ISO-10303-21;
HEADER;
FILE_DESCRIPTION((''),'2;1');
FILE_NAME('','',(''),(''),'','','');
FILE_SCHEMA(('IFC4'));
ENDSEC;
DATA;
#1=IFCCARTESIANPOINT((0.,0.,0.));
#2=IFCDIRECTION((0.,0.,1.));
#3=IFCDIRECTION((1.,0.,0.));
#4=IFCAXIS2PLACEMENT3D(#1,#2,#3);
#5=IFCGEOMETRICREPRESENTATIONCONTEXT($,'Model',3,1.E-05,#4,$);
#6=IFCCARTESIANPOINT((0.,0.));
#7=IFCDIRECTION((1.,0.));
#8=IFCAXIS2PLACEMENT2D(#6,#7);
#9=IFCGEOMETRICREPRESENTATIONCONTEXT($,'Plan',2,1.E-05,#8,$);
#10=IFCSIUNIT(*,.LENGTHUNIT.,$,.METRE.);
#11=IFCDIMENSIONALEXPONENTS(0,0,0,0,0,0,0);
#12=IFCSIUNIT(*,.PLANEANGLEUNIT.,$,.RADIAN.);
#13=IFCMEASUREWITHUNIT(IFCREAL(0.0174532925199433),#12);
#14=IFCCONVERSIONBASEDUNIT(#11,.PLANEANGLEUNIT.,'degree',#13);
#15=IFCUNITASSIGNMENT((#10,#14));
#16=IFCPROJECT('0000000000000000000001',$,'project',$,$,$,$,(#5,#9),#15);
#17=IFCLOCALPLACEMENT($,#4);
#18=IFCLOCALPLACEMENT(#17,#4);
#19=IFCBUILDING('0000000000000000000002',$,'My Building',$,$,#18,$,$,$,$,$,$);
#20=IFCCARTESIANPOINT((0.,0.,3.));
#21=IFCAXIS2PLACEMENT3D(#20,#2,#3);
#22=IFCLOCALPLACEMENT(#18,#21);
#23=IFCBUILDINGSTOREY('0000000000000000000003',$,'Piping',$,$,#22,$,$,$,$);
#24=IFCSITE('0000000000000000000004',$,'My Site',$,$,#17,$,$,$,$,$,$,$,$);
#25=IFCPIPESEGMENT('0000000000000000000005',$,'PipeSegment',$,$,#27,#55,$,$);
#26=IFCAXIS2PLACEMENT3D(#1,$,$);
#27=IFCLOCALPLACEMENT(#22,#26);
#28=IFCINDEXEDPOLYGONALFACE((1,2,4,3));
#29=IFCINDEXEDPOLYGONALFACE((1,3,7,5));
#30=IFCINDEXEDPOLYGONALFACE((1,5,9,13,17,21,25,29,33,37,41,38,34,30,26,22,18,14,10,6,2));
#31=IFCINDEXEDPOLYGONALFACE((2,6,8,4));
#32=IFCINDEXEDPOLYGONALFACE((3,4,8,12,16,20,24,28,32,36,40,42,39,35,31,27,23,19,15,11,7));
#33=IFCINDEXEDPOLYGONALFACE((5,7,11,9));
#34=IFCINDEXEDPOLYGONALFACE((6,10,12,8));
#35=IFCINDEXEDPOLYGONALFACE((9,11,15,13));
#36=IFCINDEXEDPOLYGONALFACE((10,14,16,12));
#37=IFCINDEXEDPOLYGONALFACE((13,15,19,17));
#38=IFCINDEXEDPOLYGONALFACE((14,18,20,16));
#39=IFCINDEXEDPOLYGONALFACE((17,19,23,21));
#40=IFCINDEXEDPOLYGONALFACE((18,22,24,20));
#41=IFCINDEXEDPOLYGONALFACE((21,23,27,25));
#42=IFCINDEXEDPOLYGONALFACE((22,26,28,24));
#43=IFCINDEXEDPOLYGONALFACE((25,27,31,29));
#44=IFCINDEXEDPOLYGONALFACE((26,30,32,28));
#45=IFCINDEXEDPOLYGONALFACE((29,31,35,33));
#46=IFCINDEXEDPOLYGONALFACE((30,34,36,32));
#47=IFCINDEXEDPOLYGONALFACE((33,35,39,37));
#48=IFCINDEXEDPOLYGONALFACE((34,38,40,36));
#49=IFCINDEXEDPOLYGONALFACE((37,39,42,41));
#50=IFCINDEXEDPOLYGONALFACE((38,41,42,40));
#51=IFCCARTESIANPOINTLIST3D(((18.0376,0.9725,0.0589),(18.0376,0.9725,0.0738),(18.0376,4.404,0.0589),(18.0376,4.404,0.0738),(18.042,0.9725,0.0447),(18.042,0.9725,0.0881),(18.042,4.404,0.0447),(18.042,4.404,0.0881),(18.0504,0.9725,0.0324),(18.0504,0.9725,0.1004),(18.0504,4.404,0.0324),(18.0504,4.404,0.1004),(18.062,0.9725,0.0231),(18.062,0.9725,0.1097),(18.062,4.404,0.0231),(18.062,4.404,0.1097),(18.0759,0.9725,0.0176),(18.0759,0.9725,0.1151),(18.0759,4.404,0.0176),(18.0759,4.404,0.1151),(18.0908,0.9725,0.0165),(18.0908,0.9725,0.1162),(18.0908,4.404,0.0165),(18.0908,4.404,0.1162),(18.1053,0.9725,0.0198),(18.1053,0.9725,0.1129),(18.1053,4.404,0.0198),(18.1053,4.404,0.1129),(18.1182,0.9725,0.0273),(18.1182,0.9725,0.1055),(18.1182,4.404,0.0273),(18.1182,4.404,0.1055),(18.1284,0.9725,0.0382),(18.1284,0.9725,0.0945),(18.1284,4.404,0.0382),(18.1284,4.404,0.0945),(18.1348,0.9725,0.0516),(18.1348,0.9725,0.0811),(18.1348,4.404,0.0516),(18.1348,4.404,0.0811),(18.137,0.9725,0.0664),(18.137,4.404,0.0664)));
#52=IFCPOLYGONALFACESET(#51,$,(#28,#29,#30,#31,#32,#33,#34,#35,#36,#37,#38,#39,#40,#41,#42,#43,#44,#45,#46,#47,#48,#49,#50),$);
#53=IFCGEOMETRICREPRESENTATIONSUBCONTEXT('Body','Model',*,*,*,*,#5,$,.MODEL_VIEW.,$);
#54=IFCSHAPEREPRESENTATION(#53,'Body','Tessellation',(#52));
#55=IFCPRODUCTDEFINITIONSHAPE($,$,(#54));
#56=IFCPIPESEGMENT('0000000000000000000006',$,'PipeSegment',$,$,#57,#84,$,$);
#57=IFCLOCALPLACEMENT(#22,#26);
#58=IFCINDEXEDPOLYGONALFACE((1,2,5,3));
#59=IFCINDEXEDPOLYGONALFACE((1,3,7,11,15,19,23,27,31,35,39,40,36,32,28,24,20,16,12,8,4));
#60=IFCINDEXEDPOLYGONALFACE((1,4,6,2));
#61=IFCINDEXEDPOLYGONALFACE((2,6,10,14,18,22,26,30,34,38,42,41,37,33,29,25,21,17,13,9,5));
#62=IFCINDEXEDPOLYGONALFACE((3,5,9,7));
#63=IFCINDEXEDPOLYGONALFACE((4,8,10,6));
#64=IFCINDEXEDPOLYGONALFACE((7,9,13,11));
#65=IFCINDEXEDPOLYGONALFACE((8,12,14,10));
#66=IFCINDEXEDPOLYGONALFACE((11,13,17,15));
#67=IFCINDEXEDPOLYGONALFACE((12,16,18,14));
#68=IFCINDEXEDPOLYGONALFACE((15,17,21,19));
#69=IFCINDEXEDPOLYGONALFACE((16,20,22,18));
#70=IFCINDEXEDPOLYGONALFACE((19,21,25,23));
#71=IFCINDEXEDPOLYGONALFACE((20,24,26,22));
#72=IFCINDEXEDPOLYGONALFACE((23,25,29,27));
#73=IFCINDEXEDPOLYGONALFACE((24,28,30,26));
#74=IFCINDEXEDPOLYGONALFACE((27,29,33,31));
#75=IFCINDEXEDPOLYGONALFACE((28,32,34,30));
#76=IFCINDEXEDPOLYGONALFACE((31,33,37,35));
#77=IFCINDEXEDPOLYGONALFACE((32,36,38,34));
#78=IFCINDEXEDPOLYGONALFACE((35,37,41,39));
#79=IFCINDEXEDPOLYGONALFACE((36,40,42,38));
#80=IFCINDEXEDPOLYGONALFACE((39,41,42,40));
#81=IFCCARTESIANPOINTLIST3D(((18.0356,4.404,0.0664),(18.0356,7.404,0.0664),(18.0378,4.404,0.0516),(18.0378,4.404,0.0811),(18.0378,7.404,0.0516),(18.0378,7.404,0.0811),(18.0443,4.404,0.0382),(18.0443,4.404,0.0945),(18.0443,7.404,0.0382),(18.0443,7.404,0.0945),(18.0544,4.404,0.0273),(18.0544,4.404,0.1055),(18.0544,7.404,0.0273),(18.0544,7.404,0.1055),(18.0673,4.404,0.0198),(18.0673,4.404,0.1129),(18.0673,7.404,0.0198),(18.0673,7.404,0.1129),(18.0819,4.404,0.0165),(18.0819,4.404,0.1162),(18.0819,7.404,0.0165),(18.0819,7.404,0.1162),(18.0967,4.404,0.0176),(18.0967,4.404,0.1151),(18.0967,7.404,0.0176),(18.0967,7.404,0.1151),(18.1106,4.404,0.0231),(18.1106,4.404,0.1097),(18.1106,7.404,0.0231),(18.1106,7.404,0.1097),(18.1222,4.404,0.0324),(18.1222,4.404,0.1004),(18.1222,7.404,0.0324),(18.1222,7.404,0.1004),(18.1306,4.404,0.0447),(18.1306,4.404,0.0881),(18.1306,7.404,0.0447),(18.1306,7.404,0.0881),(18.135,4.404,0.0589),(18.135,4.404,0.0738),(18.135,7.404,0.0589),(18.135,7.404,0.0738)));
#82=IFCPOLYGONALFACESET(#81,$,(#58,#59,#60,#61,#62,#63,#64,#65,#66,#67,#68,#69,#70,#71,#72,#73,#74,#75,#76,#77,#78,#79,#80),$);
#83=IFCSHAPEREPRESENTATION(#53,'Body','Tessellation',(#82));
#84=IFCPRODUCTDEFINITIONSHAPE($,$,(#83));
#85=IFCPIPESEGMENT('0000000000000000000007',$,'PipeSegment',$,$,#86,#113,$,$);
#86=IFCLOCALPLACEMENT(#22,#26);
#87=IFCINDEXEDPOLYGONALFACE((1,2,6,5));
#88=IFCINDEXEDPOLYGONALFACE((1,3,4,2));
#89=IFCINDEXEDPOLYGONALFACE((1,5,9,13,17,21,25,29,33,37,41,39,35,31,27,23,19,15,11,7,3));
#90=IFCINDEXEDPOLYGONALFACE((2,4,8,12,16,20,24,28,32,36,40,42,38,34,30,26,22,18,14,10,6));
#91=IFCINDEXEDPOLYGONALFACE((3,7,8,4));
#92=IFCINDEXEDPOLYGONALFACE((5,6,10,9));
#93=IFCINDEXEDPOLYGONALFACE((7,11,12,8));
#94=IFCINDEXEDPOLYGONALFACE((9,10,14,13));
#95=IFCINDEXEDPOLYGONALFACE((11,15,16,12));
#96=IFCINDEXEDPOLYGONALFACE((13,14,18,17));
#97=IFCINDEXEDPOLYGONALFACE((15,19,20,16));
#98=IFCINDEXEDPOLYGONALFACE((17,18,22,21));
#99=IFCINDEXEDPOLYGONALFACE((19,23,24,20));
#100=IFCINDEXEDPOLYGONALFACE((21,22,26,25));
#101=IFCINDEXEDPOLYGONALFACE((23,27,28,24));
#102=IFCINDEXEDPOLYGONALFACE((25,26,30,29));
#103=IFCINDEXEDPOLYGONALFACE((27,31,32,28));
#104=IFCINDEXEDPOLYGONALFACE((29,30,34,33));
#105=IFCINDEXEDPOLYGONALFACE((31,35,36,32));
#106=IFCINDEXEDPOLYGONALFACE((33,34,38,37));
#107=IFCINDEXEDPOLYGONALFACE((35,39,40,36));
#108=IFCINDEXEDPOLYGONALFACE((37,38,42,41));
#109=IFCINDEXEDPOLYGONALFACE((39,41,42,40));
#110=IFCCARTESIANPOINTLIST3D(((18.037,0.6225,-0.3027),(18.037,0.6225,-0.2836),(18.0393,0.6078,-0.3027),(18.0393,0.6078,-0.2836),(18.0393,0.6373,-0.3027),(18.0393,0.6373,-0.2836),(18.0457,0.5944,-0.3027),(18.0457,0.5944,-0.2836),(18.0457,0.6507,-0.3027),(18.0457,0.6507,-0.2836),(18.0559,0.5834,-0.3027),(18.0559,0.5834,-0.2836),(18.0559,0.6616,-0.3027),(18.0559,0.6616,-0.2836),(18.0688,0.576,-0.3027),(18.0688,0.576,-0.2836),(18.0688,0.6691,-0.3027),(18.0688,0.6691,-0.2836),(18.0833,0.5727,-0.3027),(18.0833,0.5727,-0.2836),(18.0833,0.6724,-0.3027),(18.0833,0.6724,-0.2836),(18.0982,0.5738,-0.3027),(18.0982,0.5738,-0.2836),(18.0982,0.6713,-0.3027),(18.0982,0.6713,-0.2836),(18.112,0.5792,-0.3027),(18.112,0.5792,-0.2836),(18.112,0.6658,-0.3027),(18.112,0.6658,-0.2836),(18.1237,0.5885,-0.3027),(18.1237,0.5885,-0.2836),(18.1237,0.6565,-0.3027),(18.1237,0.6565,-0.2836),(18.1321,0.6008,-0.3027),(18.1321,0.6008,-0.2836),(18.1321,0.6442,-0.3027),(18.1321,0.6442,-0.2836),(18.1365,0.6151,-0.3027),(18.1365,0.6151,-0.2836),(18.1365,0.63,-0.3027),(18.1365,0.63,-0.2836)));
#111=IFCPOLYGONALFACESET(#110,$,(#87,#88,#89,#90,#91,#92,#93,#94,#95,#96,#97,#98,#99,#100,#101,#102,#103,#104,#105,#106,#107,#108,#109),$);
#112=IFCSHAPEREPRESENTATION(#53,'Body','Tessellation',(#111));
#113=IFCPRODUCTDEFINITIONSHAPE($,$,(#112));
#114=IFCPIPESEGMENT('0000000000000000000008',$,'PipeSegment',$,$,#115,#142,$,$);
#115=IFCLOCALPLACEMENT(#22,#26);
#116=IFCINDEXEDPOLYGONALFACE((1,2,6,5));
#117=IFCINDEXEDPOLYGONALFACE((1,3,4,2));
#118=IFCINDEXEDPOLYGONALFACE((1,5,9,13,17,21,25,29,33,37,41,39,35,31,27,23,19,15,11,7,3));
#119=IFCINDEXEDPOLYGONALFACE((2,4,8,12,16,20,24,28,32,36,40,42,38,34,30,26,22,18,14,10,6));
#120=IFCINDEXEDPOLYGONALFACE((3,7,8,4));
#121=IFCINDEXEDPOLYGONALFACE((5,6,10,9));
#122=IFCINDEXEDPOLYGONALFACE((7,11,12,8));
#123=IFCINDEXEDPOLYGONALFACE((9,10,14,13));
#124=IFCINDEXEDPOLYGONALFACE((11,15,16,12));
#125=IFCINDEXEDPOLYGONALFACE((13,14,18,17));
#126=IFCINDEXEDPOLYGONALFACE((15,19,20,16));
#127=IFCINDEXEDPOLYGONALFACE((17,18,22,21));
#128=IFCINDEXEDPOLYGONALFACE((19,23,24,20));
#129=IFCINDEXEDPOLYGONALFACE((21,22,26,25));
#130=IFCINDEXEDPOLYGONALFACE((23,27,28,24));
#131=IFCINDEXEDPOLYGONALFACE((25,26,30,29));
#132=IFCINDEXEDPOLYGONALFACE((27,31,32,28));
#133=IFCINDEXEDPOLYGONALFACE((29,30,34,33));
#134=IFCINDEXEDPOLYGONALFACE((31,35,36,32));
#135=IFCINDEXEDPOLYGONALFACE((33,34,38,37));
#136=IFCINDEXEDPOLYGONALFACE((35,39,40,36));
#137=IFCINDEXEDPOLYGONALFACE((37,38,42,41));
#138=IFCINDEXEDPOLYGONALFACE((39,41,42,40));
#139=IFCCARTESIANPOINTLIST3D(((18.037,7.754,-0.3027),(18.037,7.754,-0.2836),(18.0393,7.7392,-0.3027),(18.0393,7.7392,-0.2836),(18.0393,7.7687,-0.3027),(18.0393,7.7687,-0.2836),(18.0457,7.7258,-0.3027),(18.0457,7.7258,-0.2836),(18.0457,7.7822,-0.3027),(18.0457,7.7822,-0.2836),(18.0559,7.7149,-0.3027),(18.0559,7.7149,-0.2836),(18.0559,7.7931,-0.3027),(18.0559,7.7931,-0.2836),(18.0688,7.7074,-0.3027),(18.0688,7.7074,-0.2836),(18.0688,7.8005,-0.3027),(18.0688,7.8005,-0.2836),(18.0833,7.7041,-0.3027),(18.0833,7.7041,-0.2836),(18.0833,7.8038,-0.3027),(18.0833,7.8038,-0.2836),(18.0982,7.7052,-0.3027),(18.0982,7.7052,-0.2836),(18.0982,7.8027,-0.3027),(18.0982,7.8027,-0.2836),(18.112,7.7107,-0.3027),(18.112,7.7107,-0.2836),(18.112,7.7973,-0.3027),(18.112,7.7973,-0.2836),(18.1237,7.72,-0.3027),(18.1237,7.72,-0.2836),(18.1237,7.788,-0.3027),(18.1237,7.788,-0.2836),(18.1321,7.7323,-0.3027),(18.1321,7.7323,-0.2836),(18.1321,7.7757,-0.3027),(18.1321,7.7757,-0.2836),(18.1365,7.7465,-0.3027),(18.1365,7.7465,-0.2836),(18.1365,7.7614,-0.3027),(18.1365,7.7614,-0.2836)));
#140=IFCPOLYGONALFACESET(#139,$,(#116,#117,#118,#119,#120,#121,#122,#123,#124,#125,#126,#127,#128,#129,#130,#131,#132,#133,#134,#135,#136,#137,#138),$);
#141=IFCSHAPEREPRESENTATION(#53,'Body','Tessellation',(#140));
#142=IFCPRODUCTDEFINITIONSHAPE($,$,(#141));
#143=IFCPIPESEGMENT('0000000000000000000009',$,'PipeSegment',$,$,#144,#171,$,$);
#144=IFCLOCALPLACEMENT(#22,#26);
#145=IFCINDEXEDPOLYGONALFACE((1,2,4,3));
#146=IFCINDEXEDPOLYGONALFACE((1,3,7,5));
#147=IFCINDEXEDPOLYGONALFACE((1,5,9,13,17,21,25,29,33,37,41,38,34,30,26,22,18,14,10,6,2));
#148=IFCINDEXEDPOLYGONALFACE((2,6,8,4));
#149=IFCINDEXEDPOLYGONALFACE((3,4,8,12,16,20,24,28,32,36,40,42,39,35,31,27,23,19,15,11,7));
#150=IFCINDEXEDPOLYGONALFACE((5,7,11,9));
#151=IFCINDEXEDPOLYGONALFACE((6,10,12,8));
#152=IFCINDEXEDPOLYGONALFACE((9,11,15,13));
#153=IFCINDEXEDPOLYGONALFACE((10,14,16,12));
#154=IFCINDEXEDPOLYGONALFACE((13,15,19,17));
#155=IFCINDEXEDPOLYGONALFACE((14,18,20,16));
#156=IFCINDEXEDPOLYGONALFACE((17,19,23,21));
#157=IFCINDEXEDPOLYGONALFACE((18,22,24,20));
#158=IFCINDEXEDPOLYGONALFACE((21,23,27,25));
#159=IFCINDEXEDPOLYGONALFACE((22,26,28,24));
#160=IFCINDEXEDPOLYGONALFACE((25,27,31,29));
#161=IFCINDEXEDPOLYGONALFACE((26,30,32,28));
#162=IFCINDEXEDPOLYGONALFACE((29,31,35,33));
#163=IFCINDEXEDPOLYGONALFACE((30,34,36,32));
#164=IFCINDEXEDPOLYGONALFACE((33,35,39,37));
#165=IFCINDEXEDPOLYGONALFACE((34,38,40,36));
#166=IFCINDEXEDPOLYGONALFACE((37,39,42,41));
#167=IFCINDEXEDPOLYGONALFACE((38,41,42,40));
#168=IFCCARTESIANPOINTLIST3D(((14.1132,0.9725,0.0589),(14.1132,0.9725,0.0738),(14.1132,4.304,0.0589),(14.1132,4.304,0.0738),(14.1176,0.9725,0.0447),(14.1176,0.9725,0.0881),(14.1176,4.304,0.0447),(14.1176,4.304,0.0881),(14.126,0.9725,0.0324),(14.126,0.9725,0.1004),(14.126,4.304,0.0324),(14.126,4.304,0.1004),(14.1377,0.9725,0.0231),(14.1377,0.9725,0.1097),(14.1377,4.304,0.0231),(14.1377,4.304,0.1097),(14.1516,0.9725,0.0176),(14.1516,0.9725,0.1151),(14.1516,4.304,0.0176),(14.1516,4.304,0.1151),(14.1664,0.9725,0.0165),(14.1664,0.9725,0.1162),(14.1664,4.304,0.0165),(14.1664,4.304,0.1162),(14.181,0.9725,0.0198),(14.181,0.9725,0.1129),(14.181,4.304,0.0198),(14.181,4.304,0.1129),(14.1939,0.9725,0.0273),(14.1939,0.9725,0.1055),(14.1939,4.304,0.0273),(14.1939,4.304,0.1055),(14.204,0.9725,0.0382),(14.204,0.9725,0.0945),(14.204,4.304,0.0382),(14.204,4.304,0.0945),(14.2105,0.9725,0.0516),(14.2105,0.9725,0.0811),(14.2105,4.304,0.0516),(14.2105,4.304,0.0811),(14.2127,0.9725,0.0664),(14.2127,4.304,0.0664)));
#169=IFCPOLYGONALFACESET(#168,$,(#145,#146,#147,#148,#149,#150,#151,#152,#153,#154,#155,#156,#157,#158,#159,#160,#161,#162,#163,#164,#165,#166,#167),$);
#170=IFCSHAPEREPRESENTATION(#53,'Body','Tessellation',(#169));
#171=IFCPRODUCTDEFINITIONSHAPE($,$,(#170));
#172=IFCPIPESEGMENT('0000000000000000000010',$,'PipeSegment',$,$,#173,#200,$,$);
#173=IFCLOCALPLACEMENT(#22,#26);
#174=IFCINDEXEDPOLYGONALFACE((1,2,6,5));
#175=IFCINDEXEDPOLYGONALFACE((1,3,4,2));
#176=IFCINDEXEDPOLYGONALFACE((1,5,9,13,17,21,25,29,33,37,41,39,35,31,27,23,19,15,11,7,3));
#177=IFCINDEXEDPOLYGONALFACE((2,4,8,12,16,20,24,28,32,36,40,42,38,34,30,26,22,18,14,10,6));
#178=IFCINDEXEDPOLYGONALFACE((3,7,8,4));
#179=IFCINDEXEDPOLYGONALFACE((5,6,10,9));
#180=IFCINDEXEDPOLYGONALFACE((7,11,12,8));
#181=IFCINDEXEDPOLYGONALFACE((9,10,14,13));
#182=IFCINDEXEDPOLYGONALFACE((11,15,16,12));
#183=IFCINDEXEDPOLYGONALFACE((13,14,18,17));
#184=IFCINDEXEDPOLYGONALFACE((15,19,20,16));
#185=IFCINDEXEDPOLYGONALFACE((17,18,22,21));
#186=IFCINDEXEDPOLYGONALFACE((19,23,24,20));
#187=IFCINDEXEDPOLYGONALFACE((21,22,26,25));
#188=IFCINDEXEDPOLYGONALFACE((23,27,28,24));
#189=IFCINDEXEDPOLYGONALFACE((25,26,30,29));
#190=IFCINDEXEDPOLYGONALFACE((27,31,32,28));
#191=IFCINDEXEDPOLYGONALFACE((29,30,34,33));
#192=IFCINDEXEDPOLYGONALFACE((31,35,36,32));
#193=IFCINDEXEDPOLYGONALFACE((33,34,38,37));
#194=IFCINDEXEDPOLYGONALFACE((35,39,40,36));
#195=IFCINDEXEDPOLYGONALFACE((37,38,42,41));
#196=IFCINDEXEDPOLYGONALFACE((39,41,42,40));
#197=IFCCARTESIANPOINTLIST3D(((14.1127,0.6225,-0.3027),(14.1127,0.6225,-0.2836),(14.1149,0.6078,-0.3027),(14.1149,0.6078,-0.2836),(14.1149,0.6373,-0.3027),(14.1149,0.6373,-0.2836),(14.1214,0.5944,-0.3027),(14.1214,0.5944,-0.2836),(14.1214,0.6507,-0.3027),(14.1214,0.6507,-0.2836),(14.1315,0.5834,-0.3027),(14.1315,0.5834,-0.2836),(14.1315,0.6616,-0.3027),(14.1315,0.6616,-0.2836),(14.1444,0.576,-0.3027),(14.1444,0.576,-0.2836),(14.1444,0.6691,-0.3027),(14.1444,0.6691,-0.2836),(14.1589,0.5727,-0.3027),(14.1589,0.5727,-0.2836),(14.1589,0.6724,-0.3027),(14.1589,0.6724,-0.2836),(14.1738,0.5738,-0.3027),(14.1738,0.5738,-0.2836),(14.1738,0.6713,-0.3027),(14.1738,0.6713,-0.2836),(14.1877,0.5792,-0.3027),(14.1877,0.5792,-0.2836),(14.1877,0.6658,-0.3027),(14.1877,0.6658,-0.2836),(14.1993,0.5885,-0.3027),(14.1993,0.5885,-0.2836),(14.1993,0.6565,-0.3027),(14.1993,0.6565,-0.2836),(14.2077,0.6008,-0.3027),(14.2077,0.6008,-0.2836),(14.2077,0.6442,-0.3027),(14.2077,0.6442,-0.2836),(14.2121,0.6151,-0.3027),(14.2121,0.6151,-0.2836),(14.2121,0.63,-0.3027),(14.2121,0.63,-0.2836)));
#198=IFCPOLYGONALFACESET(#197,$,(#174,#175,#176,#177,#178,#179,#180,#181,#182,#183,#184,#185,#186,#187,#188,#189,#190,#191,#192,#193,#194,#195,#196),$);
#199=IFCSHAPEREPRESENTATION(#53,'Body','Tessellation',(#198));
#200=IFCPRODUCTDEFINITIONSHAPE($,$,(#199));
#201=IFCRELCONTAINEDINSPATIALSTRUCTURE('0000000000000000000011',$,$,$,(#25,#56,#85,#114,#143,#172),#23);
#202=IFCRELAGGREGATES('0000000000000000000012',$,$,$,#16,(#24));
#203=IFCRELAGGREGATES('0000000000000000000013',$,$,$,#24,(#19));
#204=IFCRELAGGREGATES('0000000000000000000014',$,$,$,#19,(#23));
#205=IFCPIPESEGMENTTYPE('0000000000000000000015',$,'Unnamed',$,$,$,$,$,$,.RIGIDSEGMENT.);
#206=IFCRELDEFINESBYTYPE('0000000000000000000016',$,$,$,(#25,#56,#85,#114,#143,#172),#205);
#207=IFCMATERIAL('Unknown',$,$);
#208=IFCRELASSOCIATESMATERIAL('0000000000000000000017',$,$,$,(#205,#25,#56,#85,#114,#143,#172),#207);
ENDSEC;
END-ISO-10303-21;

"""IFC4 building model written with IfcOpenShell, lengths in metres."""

from ifc_helpers import new_model, entity, si_unit, converted_unit, frame, origin_with_axes, origin_2d_with_axis, place, context, subcontext, project, spatial, circle, extrude, material, material_profile, profile_set, profile_usage, type_object, element, save


model = new_model("IFC4")

# Units and contexts
model_context = context("Model", 3, precision=1e-05, world=origin_with_axes())
plan_context = context("Plan", 2, precision=1e-05, world=origin_2d_with_axis())
body_context = subcontext(model_context, "Body", "Model", "MODEL_VIEW")
ifc_project = project(units=[si_unit("LENGTHUNIT", "METRE"), converted_unit("PLANEANGLEUNIT", "degree", entity("IfcReal", 0.0174532925199433), si_unit("PLANEANGLEUNIT", "RADIAN"), dimensions=[0, 0, 0, 0, 0, 0, 0])], contexts=[model_context, plan_context])

# Site, building, storey
site_placement = place(None, origin_with_axes())
site = spatial("IfcSite", under=ifc_project, at=site_placement, Name="My Site")
building_placement = place(site_placement, origin_with_axes())
building = spatial("IfcBuilding", under=site, at=building_placement, Name="My Building")
storey_placement = place(building_placement, frame((0.0, 0.0, 3.0), z_axis=(0.0, 0.0, 1.0), x_axis=(1.0, 0.0, 0.0)))
storey = spatial("IfcBuildingStorey", under=building, at=storey_placement, Name="Piping")

# Pipe segments
ifc_material = material(Name="Unknown")
ifc_material_profile_1 = material_profile(ifc_material, circle(Radius=0.05))
ifc_profile_set_1 = profile_set([ifc_material_profile_1])
ifc_profile_usage_1 = profile_usage(ifc_profile_set_1, cardinal=5)
pipe_segment_type = type_object("IfcPipeSegmentType", Name="Unnamed", PredefinedType="RIGIDSEGMENT", material=ifc_profile_set_1)
pipe_segment_1_placement = place(storey_placement, frame((18.087, 4.404, 0.0664), z_axis=(0.0, -1.0, 0.000002), x_axis=(1.0, 0.0, 0.0)))
element("IfcPipeSegment", 1, at=pipe_segment_1_placement, inside=storey, type_object=pipe_segment_type, material=ifc_profile_usage_1, Name="PipeSegment", context=body_context, shape_type="SweptSolid", body=[
    extrude(circle(Radius=0.05), origin_with_axes(), (0.0, 0.0, 1.0), 3.4315),
])
ifc_profile_usage_2 = profile_usage(ifc_profile_set_1, cardinal=5)
pipe_segment_2_placement = place(storey_placement, frame((18.0856, 4.404, 0.0664), z_axis=(0.0, 1.0, 0.0), x_axis=(-1.0, 0.0, 0.0)))
element("IfcPipeSegment", 2, at=pipe_segment_2_placement, inside=storey, type_object=pipe_segment_type, material=ifc_profile_usage_2, Name="PipeSegment", context=body_context, shape_type="SweptSolid", body=[
    extrude(circle(Radius=0.05), origin_with_axes(), (0.0, 0.0, 1.0), 3.0),
])
ifc_profile_usage_3 = profile_usage(ifc_profile_set_1, cardinal=5)
pipe_segment_3_placement = place(storey_placement, frame((18.087, 0.6225, -0.2836), z_axis=(0.0, 0.0, -1.0), x_axis=(-1.0, 0.0, 0.0)))
element("IfcPipeSegment", 3, at=pipe_segment_3_placement, inside=storey, type_object=pipe_segment_type, material=ifc_profile_usage_3, Name="PipeSegment", context=body_context, shape_type="SweptSolid", body=[
    extrude(circle(Radius=0.05), origin_with_axes(), (0.0, 0.0, 1.0), 0.0191),
])
ifc_profile_usage_4 = profile_usage(ifc_profile_set_1, cardinal=5)
pipe_segment_4_placement = place(storey_placement, frame((18.087, 7.754, -0.2836), z_axis=(0.0, 0.0, -1.0), x_axis=(-1.0, 0.0, 0.0)))
element("IfcPipeSegment", 4, at=pipe_segment_4_placement, inside=storey, type_object=pipe_segment_type, material=ifc_profile_usage_4, Name="PipeSegment", context=body_context, shape_type="SweptSolid", body=[
    extrude(circle(Radius=0.05), origin_with_axes(), (0.0, 0.0, 1.0), 0.0191),
])
ifc_profile_usage_5 = profile_usage(ifc_profile_set_1, cardinal=5)
pipe_segment_5_placement = place(storey_placement, frame((14.1627, 4.304, 0.0664), z_axis=(0.0, -1.0, 0.000002), x_axis=(1.0, 0.0, 0.0)))
element("IfcPipeSegment", 5, at=pipe_segment_5_placement, inside=storey, type_object=pipe_segment_type, material=ifc_profile_usage_5, Name="PipeSegment", context=body_context, shape_type="SweptSolid", body=[
    extrude(circle(Radius=0.05), origin_with_axes(), (0.0, 0.0, 1.0), 3.3315),
])
ifc_profile_usage_6 = profile_usage(ifc_profile_set_1, cardinal=5)
pipe_segment_6_placement = place(storey_placement, frame((14.1627, 0.6225, -0.2836), z_axis=(0.0, 0.0, -1.0), x_axis=(-1.0, 0.0, 0.0)))
element("IfcPipeSegment", 6, at=pipe_segment_6_placement, inside=storey, type_object=pipe_segment_type, material=ifc_profile_usage_6, Name="PipeSegment", context=body_context, shape_type="SweptSolid", body=[
    extrude(circle(Radius=0.05), origin_with_axes(), (0.0, 0.0, 1.0), 0.0191),
])

save(model, "model.ifc")
